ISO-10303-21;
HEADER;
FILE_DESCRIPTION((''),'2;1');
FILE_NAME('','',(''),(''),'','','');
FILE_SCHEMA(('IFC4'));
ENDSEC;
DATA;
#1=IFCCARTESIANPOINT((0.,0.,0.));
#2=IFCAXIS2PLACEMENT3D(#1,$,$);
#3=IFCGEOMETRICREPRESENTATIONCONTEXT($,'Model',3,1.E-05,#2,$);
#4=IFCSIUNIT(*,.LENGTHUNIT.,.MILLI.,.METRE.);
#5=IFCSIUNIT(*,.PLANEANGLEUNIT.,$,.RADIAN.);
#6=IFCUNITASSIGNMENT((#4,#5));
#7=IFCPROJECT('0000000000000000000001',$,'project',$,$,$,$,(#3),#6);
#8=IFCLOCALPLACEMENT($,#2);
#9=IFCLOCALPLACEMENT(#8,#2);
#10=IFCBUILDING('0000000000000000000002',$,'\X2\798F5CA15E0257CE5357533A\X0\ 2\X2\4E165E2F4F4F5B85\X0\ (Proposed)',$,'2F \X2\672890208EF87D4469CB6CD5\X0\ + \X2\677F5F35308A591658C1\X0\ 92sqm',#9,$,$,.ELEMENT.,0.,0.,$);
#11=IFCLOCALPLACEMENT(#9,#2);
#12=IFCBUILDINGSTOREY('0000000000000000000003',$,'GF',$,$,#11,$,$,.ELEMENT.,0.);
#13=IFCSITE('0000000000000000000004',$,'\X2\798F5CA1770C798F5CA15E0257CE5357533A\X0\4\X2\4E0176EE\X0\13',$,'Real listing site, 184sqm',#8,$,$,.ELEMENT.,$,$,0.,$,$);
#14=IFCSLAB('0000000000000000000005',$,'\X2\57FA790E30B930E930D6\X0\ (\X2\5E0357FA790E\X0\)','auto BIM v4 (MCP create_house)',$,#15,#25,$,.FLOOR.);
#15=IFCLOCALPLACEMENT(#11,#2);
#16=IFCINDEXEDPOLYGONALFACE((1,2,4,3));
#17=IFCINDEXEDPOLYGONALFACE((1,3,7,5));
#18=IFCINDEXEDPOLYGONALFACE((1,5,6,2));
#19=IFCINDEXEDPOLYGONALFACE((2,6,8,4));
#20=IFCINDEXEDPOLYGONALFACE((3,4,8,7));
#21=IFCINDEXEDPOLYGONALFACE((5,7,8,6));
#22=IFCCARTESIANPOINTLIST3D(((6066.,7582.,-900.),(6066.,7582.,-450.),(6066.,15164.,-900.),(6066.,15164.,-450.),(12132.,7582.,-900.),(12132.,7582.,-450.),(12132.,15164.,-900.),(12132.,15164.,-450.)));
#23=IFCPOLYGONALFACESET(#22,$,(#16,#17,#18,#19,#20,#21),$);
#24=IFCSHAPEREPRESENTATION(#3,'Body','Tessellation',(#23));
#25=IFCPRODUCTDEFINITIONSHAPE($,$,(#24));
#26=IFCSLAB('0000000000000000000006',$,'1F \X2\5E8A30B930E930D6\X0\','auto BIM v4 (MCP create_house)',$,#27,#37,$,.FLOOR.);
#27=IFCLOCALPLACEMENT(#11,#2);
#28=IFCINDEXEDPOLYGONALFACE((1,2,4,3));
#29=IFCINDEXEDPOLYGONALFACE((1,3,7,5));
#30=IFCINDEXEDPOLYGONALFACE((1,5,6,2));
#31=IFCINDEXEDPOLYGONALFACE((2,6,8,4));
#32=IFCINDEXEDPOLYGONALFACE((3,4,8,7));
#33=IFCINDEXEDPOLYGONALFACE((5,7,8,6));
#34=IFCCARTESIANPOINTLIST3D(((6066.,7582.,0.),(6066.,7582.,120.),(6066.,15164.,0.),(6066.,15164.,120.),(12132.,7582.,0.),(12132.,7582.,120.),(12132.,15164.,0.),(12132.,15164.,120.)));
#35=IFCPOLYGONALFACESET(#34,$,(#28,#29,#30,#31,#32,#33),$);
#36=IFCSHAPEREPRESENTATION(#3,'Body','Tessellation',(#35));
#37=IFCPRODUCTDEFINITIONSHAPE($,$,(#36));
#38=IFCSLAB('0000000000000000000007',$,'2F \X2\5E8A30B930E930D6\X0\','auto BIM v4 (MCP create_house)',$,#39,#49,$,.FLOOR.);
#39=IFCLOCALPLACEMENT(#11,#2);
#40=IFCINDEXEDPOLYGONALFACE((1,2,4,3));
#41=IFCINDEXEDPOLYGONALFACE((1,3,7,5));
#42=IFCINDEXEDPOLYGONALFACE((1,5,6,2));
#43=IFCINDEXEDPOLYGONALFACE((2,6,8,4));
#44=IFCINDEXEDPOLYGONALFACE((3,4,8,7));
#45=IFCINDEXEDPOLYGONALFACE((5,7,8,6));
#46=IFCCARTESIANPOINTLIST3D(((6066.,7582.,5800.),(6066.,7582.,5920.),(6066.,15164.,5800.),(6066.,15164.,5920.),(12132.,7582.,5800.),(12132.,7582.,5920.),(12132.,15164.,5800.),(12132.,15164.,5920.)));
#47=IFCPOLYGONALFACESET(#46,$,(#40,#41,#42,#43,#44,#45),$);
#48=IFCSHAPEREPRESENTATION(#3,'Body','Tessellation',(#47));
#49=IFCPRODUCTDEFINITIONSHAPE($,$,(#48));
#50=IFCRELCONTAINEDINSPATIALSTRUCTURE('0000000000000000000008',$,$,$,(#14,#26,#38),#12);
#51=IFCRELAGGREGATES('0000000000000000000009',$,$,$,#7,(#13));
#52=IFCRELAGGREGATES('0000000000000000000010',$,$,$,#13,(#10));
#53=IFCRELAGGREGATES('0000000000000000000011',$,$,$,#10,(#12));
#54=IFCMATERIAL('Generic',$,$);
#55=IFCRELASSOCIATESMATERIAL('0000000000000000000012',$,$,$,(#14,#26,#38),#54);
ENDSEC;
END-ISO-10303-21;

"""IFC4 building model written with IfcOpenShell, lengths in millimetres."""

from ifc_helpers import new_model, si_unit, frame, frame_2d, origin, place, context, project, spatial, rectangle, extrude, material, element, save


model = new_model("IFC4")

# Units and contexts
model_context = context("Model", 3, precision=1e-05, world=origin())
ifc_project = project(units=[si_unit("LENGTHUNIT", "METRE", prefix="MILLI"), si_unit("PLANEANGLEUNIT", "RADIAN")], contexts=[model_context])

# Site, building, storey
site_placement = place(None, origin())
site = spatial("IfcSite", under=ifc_project, at=site_placement, Name="福岡県福岡市城南区4丁目13", ObjectType="Real listing site, 184sqm", CompositionType="ELEMENT", RefElevation=0.0)
building_placement = place(site_placement, origin())
building = spatial("IfcBuilding", under=site, at=building_placement, Name="福岡市城南区 2世帯住宅 (Proposed)", ObjectType="2F 木造軸組構法 + 板張り外壁 92sqm", CompositionType="ELEMENT", ElevationOfRefHeight=0.0, ElevationOfTerrain=0.0)
storey_placement = place(building_placement, origin())
storey = spatial("IfcBuildingStorey", under=building, at=storey_placement, Name="GF", CompositionType="ELEMENT", Elevation=0.0)

# Slabs
ifc_material = material(Name="Generic")
slab_1_placement = place(storey_placement, frame((3033.0, 3791.0, -450.0)))
element("IfcSlab", 1, at=slab_1_placement, inside=storey, material=ifc_material, Name="基礎スラブ (布基礎)", Description="auto BIM v4 (MCP create_house)", PredefinedType="FLOOR", context=model_context, shape_type="SweptSolid", body=[
    extrude(rectangle(XDim=6066.0, YDim=7582.0, at=frame_2d((3033.0, 3791.0))), frame((3033.0, 3791.0, -450.0)), (0.0, 0.0, 1.0), 450.0),
])
slab_2_placement = place(storey_placement, frame((3033.0, 3791.0, 0.0)))
element("IfcSlab", 2, at=slab_2_placement, inside=storey, material=ifc_material, Name="1F 床スラブ", Description="auto BIM v4 (MCP create_house)", PredefinedType="FLOOR", context=model_context, shape_type="SweptSolid", body=[
    extrude(rectangle(XDim=6066.0, YDim=7582.0, at=frame_2d((3033.0, 3791.0))), frame((3033.0, 3791.0, 0.0)), (0.0, 0.0, 1.0), 120.0),
])
slab_3_placement = place(storey_placement, frame((3033.0, 3791.0, 2900.0)))
element("IfcSlab", 3, at=slab_3_placement, inside=storey, material=ifc_material, Name="2F 床スラブ", Description="auto BIM v4 (MCP create_house)", PredefinedType="FLOOR", context=model_context, shape_type="SweptSolid", body=[
    extrude(rectangle(XDim=6066.0, YDim=7582.0, at=frame_2d((3033.0, 3791.0))), frame((3033.0, 3791.0, 2900.0)), (0.0, 0.0, 1.0), 120.0),
])

save(model, "model.ifc")
